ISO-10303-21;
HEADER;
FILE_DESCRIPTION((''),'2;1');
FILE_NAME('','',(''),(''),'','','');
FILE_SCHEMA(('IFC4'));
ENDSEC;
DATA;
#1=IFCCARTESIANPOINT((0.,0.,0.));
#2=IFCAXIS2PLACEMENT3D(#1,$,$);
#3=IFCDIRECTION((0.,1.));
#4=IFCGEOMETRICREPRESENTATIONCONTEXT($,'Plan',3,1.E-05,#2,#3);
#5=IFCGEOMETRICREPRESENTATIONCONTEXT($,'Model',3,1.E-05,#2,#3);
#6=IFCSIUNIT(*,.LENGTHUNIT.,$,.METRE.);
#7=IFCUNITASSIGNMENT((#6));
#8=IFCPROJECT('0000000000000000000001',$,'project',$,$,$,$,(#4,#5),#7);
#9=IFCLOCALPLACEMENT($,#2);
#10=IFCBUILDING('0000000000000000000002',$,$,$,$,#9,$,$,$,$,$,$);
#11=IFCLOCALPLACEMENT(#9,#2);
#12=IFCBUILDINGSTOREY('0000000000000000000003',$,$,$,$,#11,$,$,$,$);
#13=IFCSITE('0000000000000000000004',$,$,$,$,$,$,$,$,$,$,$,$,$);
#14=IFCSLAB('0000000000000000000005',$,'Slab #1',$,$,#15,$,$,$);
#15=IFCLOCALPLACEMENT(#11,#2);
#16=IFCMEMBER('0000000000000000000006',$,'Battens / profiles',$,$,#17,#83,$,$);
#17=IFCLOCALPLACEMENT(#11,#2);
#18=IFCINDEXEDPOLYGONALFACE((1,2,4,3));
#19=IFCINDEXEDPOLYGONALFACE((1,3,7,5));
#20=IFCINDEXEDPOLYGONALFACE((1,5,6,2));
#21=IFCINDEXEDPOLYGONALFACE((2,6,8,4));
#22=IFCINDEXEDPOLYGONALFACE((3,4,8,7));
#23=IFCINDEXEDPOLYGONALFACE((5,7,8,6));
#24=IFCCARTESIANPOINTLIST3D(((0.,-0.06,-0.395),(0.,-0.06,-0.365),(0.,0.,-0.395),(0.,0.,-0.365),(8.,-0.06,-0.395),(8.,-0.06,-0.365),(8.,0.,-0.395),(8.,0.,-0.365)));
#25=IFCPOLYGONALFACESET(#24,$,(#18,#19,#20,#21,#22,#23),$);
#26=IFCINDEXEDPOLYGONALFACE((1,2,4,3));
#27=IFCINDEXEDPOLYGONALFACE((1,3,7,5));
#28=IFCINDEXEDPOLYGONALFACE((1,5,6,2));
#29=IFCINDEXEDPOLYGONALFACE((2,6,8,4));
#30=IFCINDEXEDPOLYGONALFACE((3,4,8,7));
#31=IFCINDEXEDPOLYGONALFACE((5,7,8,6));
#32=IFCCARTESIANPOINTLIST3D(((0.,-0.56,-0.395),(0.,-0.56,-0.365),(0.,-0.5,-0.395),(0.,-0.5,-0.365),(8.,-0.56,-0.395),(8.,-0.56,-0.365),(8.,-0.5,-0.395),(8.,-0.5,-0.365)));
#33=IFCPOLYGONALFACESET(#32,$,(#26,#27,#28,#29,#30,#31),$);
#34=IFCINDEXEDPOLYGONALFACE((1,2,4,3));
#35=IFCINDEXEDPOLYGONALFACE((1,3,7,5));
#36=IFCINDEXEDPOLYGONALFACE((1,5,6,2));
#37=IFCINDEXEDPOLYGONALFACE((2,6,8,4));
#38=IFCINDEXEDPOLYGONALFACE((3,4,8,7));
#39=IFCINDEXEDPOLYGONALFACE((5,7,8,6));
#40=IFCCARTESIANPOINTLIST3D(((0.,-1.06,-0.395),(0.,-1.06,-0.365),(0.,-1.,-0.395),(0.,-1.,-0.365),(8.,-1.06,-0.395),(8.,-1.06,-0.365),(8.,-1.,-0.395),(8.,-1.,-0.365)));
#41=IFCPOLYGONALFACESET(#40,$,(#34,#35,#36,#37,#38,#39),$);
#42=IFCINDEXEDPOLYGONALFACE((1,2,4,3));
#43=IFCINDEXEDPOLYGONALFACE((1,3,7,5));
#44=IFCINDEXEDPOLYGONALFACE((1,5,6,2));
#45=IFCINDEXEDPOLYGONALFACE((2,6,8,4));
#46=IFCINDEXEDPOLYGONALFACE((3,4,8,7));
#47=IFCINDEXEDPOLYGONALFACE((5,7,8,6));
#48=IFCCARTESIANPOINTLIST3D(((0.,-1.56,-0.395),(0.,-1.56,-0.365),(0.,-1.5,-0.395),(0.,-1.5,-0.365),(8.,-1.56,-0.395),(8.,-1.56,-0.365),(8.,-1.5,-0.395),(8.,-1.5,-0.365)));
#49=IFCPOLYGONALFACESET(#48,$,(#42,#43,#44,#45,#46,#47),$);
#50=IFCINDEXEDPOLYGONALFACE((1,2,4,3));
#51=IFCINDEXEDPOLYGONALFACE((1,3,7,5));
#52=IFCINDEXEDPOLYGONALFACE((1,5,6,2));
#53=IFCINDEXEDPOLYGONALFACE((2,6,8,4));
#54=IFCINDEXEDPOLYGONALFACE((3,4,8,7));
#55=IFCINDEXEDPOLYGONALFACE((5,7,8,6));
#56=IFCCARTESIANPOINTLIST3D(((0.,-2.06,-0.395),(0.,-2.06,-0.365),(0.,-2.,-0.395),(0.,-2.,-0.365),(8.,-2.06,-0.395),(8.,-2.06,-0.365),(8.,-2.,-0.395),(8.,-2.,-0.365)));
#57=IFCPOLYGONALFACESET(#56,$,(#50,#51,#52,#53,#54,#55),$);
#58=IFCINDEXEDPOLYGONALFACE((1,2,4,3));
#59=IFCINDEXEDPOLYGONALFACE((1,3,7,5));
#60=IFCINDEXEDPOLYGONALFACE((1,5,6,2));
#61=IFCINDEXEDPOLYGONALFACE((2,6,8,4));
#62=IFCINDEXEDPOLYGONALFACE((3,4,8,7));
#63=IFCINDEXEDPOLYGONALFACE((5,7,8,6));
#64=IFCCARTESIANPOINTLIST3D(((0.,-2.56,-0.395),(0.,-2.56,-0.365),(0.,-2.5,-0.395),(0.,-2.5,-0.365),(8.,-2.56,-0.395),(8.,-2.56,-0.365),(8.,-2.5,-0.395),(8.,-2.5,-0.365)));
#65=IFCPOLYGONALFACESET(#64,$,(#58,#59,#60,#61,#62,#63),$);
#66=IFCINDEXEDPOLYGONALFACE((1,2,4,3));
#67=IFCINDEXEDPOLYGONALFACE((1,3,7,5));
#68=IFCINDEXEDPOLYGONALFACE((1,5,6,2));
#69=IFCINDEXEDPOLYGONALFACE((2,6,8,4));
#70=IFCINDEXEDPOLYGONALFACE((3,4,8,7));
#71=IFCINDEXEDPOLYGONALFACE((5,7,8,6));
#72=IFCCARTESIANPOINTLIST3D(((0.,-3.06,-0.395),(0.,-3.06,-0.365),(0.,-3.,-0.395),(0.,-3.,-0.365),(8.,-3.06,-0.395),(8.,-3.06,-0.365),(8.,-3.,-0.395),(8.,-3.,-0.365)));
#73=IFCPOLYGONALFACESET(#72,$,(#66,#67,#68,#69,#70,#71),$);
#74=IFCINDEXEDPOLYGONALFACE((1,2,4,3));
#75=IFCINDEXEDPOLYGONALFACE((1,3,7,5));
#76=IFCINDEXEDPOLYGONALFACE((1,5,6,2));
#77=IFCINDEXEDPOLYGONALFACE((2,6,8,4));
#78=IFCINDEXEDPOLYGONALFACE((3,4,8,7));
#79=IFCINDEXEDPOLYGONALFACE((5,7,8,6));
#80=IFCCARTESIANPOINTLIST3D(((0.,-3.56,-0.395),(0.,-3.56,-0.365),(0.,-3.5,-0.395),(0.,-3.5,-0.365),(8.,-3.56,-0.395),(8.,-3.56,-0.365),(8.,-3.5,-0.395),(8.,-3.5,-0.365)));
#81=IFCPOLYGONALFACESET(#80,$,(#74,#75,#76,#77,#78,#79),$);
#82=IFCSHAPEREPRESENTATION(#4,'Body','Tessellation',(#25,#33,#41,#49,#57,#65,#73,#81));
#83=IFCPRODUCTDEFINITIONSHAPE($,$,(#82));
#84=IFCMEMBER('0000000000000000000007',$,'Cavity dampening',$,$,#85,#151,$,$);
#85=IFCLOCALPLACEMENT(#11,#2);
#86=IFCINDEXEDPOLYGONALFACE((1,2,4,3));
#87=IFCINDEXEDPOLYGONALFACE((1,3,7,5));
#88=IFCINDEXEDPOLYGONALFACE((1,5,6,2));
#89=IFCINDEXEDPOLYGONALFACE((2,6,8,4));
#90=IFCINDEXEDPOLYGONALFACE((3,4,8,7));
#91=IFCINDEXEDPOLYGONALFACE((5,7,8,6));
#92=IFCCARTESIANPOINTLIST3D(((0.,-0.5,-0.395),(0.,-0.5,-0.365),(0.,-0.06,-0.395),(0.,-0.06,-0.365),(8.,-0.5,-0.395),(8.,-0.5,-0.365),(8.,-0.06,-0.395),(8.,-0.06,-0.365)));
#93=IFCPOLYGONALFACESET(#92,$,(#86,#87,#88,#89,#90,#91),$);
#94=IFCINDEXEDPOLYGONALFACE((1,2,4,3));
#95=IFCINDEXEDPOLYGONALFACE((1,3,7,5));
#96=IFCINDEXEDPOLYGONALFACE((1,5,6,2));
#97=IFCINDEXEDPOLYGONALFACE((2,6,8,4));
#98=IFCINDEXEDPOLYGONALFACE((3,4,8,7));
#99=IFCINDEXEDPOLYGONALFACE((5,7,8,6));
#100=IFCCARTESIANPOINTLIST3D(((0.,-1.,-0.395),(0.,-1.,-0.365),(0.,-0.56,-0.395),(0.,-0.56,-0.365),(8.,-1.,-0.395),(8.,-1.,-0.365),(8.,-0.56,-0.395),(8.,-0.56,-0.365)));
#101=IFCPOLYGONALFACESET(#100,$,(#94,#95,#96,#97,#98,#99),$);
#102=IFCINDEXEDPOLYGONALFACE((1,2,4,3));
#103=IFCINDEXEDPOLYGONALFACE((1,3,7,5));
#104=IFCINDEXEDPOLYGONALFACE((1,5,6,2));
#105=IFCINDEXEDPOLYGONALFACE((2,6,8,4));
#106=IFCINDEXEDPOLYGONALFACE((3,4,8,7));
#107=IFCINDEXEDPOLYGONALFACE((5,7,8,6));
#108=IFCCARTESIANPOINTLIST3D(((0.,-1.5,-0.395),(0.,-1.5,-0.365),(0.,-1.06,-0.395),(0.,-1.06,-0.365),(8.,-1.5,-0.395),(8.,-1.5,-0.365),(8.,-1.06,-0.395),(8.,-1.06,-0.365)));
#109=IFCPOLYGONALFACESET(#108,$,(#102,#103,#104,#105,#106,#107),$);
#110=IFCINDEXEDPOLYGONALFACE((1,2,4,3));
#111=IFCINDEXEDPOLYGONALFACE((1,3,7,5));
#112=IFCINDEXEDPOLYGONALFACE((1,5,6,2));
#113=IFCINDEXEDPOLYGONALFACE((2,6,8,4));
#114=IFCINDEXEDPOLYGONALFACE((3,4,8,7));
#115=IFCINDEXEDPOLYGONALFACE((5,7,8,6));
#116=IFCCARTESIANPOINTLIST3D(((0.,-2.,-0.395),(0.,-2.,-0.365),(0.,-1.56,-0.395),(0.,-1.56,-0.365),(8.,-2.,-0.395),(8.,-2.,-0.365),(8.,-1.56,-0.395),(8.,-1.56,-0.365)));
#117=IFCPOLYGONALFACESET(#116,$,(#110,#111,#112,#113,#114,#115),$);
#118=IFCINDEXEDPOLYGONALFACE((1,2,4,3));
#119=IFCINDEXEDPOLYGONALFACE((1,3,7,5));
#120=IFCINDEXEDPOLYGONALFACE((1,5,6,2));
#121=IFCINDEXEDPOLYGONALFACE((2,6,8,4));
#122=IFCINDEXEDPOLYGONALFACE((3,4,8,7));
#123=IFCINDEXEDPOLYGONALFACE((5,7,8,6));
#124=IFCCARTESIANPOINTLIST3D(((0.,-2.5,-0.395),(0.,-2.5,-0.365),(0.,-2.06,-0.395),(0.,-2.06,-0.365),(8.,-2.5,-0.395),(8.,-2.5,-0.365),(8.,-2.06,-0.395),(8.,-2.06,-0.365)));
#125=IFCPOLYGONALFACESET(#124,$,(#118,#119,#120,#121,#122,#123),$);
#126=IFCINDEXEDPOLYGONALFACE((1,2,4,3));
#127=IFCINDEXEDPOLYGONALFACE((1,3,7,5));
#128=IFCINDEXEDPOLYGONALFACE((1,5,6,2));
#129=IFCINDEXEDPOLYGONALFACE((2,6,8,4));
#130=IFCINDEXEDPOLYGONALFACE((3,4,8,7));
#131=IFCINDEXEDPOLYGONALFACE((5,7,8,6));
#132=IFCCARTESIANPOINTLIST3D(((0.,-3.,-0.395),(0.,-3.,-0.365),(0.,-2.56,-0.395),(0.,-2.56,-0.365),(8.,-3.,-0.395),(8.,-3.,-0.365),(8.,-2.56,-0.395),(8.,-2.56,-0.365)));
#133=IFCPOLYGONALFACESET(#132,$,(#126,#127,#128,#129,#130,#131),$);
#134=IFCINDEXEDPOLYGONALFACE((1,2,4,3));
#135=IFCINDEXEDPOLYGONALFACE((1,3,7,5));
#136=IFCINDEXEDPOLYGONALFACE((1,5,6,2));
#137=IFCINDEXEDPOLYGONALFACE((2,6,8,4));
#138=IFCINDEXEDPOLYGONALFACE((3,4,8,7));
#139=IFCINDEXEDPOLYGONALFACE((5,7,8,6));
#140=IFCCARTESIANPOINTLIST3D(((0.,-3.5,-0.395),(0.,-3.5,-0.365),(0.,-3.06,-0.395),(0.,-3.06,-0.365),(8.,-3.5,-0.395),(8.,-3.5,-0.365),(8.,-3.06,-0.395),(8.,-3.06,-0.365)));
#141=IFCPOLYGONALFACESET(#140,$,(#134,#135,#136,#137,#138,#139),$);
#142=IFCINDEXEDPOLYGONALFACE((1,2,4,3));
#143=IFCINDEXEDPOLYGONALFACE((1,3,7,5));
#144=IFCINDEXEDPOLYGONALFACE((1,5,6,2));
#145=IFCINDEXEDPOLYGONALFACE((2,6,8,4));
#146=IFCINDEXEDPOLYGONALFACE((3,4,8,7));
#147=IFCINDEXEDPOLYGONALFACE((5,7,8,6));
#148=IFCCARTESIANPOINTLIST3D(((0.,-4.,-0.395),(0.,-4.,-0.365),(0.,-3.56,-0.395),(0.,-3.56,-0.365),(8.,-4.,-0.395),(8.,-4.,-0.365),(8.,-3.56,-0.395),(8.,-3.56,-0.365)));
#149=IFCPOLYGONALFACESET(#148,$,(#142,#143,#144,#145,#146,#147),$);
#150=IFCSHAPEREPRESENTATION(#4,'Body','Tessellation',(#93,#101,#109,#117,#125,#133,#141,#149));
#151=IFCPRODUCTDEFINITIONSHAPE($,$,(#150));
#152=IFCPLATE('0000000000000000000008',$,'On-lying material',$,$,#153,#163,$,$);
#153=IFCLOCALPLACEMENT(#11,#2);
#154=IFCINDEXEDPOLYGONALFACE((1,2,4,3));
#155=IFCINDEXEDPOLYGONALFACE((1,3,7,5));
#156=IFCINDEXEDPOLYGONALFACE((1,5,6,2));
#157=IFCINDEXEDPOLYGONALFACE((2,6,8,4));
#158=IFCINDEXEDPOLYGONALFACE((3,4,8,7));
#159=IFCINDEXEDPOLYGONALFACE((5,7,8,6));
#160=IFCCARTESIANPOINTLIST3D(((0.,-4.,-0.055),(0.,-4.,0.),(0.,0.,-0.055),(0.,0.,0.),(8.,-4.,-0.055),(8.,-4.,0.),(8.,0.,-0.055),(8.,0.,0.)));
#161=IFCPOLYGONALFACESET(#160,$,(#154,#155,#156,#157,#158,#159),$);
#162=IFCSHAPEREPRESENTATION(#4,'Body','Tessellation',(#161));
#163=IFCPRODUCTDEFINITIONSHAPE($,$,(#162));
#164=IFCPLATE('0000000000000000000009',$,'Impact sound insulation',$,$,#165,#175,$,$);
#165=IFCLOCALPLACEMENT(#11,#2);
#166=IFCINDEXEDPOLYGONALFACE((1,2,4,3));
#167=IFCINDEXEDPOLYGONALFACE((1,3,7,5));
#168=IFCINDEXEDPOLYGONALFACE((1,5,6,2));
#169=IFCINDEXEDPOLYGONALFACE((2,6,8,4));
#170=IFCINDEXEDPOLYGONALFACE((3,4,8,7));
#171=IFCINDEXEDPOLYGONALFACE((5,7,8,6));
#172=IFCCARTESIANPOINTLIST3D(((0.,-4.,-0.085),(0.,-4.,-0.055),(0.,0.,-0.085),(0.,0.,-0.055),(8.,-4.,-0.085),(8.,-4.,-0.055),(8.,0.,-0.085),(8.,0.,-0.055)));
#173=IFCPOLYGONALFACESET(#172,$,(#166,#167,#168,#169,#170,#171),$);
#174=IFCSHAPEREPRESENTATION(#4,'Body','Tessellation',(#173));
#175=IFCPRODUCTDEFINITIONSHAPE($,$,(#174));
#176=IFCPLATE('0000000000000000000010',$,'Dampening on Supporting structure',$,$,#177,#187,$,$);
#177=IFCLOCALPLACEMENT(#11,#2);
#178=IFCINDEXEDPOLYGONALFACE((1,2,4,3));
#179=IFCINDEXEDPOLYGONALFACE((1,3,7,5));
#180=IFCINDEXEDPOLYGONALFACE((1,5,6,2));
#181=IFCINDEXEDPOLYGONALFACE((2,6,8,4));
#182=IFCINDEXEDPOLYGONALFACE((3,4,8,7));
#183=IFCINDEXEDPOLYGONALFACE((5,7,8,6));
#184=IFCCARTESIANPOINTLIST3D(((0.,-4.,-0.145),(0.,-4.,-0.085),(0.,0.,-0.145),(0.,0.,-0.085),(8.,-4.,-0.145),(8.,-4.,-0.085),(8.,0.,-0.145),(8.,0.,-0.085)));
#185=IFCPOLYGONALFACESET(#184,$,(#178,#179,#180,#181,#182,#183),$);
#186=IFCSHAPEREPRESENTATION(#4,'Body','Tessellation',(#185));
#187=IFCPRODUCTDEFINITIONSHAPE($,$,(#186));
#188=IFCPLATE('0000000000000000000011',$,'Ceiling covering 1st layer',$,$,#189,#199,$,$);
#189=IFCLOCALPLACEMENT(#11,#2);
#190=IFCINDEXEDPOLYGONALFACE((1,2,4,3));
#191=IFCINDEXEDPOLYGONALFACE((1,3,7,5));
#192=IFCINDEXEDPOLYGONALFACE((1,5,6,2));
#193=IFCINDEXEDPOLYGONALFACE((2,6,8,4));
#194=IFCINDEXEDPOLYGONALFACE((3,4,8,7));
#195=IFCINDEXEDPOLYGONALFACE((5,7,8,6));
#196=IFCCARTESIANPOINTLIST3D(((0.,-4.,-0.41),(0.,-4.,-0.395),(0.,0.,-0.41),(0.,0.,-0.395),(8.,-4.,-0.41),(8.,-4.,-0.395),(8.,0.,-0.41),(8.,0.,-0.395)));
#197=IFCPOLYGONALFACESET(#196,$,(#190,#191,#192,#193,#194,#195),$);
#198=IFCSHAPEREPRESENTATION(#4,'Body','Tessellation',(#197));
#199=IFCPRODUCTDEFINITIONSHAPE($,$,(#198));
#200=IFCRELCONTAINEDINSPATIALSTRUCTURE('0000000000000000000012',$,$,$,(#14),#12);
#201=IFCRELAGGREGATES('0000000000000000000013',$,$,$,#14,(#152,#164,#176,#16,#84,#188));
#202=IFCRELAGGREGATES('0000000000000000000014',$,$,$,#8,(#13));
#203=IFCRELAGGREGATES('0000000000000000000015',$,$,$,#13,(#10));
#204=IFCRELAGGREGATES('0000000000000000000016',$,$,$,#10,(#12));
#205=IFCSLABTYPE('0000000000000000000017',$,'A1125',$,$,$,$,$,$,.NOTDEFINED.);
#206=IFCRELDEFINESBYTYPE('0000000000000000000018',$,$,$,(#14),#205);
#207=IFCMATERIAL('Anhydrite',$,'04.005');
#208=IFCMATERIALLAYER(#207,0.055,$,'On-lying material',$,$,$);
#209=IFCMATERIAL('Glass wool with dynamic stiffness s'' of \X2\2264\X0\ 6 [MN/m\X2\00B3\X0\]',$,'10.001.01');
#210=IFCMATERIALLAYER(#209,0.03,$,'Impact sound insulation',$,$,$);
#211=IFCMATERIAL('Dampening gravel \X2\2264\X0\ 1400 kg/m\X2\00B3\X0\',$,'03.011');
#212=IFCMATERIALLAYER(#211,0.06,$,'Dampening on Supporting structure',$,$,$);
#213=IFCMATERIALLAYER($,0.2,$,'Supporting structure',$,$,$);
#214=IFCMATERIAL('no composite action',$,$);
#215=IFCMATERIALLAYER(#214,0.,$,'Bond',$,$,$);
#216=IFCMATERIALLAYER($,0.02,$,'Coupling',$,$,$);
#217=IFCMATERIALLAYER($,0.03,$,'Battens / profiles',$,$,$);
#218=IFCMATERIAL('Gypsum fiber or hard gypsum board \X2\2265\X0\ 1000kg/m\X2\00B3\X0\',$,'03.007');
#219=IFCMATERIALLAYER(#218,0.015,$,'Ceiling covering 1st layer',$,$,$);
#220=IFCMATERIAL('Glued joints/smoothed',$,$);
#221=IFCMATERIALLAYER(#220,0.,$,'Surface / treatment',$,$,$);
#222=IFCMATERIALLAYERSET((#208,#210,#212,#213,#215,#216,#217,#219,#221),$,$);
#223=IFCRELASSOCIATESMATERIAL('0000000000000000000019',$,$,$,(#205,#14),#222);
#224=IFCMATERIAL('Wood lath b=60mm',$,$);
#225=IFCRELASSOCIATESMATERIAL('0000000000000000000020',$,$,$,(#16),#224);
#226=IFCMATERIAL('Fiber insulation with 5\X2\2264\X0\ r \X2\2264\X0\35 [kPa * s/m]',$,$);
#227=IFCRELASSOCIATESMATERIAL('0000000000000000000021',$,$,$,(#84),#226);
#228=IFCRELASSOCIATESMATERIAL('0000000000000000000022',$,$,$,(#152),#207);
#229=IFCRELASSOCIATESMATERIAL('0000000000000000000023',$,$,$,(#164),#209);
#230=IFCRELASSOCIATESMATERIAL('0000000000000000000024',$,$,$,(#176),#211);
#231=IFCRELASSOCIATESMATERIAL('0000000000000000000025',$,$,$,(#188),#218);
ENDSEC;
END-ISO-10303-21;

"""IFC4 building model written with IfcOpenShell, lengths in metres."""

from ifc_helpers import new_model, si_unit, direction, frame, frame_2d, origin, origin_with_axes, place, context, project, spatial, rectangle, extrude, material, layer, layer_set, type_object, element, aggregate, save


model = new_model("IFC4")

# Units and contexts
plan_context = context("Plan", 3, precision=1e-05, world=origin(), true_north=direction((0.0, 1.0)))
model_context = context("Model", 3, precision=1e-05, world=origin(), true_north=direction((0.0, 1.0)))
ifc_project = project(units=[si_unit("LENGTHUNIT", "METRE")], contexts=[plan_context, model_context])

# Site, building, storey
site = spatial("IfcSite", under=ifc_project)
building_placement = place(None, origin())
building = spatial("IfcBuilding", under=site, at=building_placement)
storey_placement = place(building_placement, origin())
storey = spatial("IfcBuildingStorey", under=building, at=storey_placement)

# Slab, members, plates
ifc_material_1 = material(Name="Anhydrite", Category="04.005")
ifc_layer_1 = layer(ifc_material_1, 0.055, Name="On-lying material")
ifc_material_2 = material(Name="Glass wool with dynamic stiffness s' of ≤ 6 [MN/m³]", Category="10.001.01")
ifc_layer_2 = layer(ifc_material_2, 0.03, Name="Impact sound insulation")
ifc_material_3 = material(Name="Dampening gravel ≤ 1400 kg/m³", Category="03.011")
ifc_layer_3 = layer(ifc_material_3, 0.06, Name="Dampening on Supporting structure")
ifc_layer_4 = layer(None, 0.2, Name="Supporting structure")
ifc_material_4 = material(Name="no composite action")
ifc_layer_5 = layer(ifc_material_4, 0.0, Name="Bond")
ifc_layer_6 = layer(None, 0.02, Name="Coupling")
ifc_layer_7 = layer(None, 0.03, Name="Battens / profiles")
ifc_material_5 = material(Name="Gypsum fiber or hard gypsum board ≥ 1000kg/m³", Category="03.007")
ifc_layer_8 = layer(ifc_material_5, 0.015, Name="Ceiling covering 1st layer")
ifc_material_6 = material(Name="Glued joints/smoothed")
ifc_layer_9 = layer(ifc_material_6, 0.0, Name="Surface / treatment")
ifc_layer_set = layer_set([ifc_layer_1, ifc_layer_2, ifc_layer_3, ifc_layer_4, ifc_layer_5, ifc_layer_6, ifc_layer_7, ifc_layer_8, ifc_layer_9])
slab_type = type_object("IfcSlabType", Name="A1125", PredefinedType="NOTDEFINED", material=ifc_layer_set)
slab_placement = place(None, frame((0.0, 0.0, 0.0), z_axis=(0.0, 0.0, -1.0), x_axis=(1.0, 0.0, 0.0)))
slab = element("IfcSlab", 1, at=slab_placement, inside=storey, type_object=slab_type, material=ifc_layer_set, Name="Slab #1")
ifc_material_7 = material(Name="Wood lath b=60mm")
member_1_placement = place(slab_placement, origin())
member_1 = element("IfcMember", 2, at=member_1_placement, material=ifc_material_7, Name="Battens / profiles", context=plan_context, shape_type="SweptSolid", body=[
    extrude(rectangle(XDim=0.06, YDim=0.03, at=frame_2d((0.03, 0.015), x_axis=(1.0, 0.0))), frame((0.0, 0.0, 0.365), z_axis=(1.0, 0.0, 0.0), x_axis=(0.0, 1.0, 0.0)), (0.0, 0.0, 1.0), 8.0),
    extrude(rectangle(XDim=0.06, YDim=0.03, at=frame_2d((0.03, 0.015), x_axis=(1.0, 0.0))), frame((0.0, 0.5, 0.365), z_axis=(1.0, 0.0, 0.0), x_axis=(0.0, 1.0, 0.0)), (0.0, 0.0, 1.0), 8.0),
    extrude(rectangle(XDim=0.06, YDim=0.03, at=frame_2d((0.03, 0.015), x_axis=(1.0, 0.0))), frame((0.0, 1.0, 0.365), z_axis=(1.0, 0.0, 0.0), x_axis=(0.0, 1.0, 0.0)), (0.0, 0.0, 1.0), 8.0),
    extrude(rectangle(XDim=0.06, YDim=0.03, at=frame_2d((0.03, 0.015), x_axis=(1.0, 0.0))), frame((0.0, 1.5, 0.365), z_axis=(1.0, 0.0, 0.0), x_axis=(0.0, 1.0, 0.0)), (0.0, 0.0, 1.0), 8.0),
    extrude(rectangle(XDim=0.06, YDim=0.03, at=frame_2d((0.03, 0.015), x_axis=(1.0, 0.0))), frame((0.0, 2.0, 0.365), z_axis=(1.0, 0.0, 0.0), x_axis=(0.0, 1.0, 0.0)), (0.0, 0.0, 1.0), 8.0),
    extrude(rectangle(XDim=0.06, YDim=0.03, at=frame_2d((0.03, 0.015), x_axis=(1.0, 0.0))), frame((0.0, 2.5, 0.365), z_axis=(1.0, 0.0, 0.0), x_axis=(0.0, 1.0, 0.0)), (0.0, 0.0, 1.0), 8.0),
    extrude(rectangle(XDim=0.06, YDim=0.03, at=frame_2d((0.03, 0.015), x_axis=(1.0, 0.0))), frame((0.0, 3.0, 0.365), z_axis=(1.0, 0.0, 0.0), x_axis=(0.0, 1.0, 0.0)), (0.0, 0.0, 1.0), 8.0),
    extrude(rectangle(XDim=0.06, YDim=0.03, at=frame_2d((0.03, 0.015), x_axis=(1.0, 0.0))), frame((0.0, 3.5, 0.365), z_axis=(1.0, 0.0, 0.0), x_axis=(0.0, 1.0, 0.0)), (0.0, 0.0, 1.0), 8.0),
])
ifc_material_8 = material(Name="Fiber insulation with 5≤ r ≤35 [kPa * s/m]")
member_2_placement = place(slab_placement, origin())
member_2 = element("IfcMember", 3, at=member_2_placement, material=ifc_material_8, Name="Cavity dampening", context=plan_context, shape_type="SweptSolid", body=[
    extrude(rectangle(XDim=0.44, YDim=0.03, at=frame_2d((0.22, 0.015), x_axis=(1.0, 0.0))), frame((0.0, 0.06, 0.365), z_axis=(1.0, 0.0, 0.0), x_axis=(0.0, 1.0, 0.0)), (0.0, 0.0, 1.0), 8.0),
    extrude(rectangle(XDim=0.44, YDim=0.03, at=frame_2d((0.22, 0.015), x_axis=(1.0, 0.0))), frame((0.0, 0.56, 0.365), z_axis=(1.0, 0.0, 0.0), x_axis=(0.0, 1.0, 0.0)), (0.0, 0.0, 1.0), 8.0),
    extrude(rectangle(XDim=0.44, YDim=0.03, at=frame_2d((0.22, 0.015), x_axis=(1.0, 0.0))), frame((0.0, 1.06, 0.365), z_axis=(1.0, 0.0, 0.0), x_axis=(0.0, 1.0, 0.0)), (0.0, 0.0, 1.0), 8.0),
    extrude(rectangle(XDim=0.44, YDim=0.03, at=frame_2d((0.22, 0.015), x_axis=(1.0, 0.0))), frame((0.0, 1.56, 0.365), z_axis=(1.0, 0.0, 0.0), x_axis=(0.0, 1.0, 0.0)), (0.0, 0.0, 1.0), 8.0),
    extrude(rectangle(XDim=0.44, YDim=0.03, at=frame_2d((0.22, 0.015), x_axis=(1.0, 0.0))), frame((0.0, 2.06, 0.365), z_axis=(1.0, 0.0, 0.0), x_axis=(0.0, 1.0, 0.0)), (0.0, 0.0, 1.0), 8.0),
    extrude(rectangle(XDim=0.44, YDim=0.03, at=frame_2d((0.22, 0.015), x_axis=(1.0, 0.0))), frame((0.0, 2.56, 0.365), z_axis=(1.0, 0.0, 0.0), x_axis=(0.0, 1.0, 0.0)), (0.0, 0.0, 1.0), 8.0),
    extrude(rectangle(XDim=0.44, YDim=0.03, at=frame_2d((0.22, 0.015), x_axis=(1.0, 0.0))), frame((0.0, 3.06, 0.365), z_axis=(1.0, 0.0, 0.0), x_axis=(0.0, 1.0, 0.0)), (0.0, 0.0, 1.0), 8.0),
    extrude(rectangle(XDim=0.44, YDim=0.03, at=frame_2d((0.22, 0.015), x_axis=(1.0, 0.0))), frame((0.0, 3.56, 0.365), z_axis=(1.0, 0.0, 0.0), x_axis=(0.0, 1.0, 0.0)), (0.0, 0.0, 1.0), 8.0),
])
plate_1_placement = place(slab_placement, origin())
plate_1 = element("IfcPlate", 4, at=plate_1_placement, material=ifc_material_1, Name="On-lying material", context=plan_context, shape_type="SweptSolid", body=[
    extrude(rectangle(XDim=8.0, YDim=4.0, at=frame_2d((4.0, 2.0), x_axis=(1.0, 0.0))), origin_with_axes(), (0.0, 0.0, 1.0), 0.055),
])
plate_2_placement = place(slab_placement, origin())
plate_2 = element("IfcPlate", 5, at=plate_2_placement, material=ifc_material_2, Name="Impact sound insulation", context=plan_context, shape_type="SweptSolid", body=[
    extrude(rectangle(XDim=8.0, YDim=4.0, at=frame_2d((4.0, 2.0), x_axis=(1.0, 0.0))), frame((0.0, 0.0, 0.055), z_axis=(0.0, 0.0, 1.0), x_axis=(1.0, 0.0, 0.0)), (0.0, 0.0, 1.0), 0.03),
])
plate_3_placement = place(slab_placement, origin())
plate_3 = element("IfcPlate", 6, at=plate_3_placement, material=ifc_material_3, Name="Dampening on Supporting structure", context=plan_context, shape_type="SweptSolid", body=[
    extrude(rectangle(XDim=8.0, YDim=4.0, at=frame_2d((4.0, 2.0), x_axis=(1.0, 0.0))), frame((0.0, 0.0, 0.085), z_axis=(0.0, 0.0, 1.0), x_axis=(1.0, 0.0, 0.0)), (0.0, 0.0, 1.0), 0.06),
])
plate_4_placement = place(slab_placement, origin())
plate_4 = element("IfcPlate", 7, at=plate_4_placement, material=ifc_material_5, Name="Ceiling covering 1st layer", context=plan_context, shape_type="SweptSolid", body=[
    extrude(rectangle(XDim=8.0, YDim=4.0, at=frame_2d((4.0, 2.0), x_axis=(1.0, 0.0))), frame((0.0, 0.0, 0.395), z_axis=(0.0, 0.0, 1.0), x_axis=(1.0, 0.0, 0.0)), (0.0, 0.0, 1.0), 0.015),
])
aggregate(slab, [plate_1, plate_2, plate_3, member_1, member_2, plate_4])

save(model, "model.ifc")
